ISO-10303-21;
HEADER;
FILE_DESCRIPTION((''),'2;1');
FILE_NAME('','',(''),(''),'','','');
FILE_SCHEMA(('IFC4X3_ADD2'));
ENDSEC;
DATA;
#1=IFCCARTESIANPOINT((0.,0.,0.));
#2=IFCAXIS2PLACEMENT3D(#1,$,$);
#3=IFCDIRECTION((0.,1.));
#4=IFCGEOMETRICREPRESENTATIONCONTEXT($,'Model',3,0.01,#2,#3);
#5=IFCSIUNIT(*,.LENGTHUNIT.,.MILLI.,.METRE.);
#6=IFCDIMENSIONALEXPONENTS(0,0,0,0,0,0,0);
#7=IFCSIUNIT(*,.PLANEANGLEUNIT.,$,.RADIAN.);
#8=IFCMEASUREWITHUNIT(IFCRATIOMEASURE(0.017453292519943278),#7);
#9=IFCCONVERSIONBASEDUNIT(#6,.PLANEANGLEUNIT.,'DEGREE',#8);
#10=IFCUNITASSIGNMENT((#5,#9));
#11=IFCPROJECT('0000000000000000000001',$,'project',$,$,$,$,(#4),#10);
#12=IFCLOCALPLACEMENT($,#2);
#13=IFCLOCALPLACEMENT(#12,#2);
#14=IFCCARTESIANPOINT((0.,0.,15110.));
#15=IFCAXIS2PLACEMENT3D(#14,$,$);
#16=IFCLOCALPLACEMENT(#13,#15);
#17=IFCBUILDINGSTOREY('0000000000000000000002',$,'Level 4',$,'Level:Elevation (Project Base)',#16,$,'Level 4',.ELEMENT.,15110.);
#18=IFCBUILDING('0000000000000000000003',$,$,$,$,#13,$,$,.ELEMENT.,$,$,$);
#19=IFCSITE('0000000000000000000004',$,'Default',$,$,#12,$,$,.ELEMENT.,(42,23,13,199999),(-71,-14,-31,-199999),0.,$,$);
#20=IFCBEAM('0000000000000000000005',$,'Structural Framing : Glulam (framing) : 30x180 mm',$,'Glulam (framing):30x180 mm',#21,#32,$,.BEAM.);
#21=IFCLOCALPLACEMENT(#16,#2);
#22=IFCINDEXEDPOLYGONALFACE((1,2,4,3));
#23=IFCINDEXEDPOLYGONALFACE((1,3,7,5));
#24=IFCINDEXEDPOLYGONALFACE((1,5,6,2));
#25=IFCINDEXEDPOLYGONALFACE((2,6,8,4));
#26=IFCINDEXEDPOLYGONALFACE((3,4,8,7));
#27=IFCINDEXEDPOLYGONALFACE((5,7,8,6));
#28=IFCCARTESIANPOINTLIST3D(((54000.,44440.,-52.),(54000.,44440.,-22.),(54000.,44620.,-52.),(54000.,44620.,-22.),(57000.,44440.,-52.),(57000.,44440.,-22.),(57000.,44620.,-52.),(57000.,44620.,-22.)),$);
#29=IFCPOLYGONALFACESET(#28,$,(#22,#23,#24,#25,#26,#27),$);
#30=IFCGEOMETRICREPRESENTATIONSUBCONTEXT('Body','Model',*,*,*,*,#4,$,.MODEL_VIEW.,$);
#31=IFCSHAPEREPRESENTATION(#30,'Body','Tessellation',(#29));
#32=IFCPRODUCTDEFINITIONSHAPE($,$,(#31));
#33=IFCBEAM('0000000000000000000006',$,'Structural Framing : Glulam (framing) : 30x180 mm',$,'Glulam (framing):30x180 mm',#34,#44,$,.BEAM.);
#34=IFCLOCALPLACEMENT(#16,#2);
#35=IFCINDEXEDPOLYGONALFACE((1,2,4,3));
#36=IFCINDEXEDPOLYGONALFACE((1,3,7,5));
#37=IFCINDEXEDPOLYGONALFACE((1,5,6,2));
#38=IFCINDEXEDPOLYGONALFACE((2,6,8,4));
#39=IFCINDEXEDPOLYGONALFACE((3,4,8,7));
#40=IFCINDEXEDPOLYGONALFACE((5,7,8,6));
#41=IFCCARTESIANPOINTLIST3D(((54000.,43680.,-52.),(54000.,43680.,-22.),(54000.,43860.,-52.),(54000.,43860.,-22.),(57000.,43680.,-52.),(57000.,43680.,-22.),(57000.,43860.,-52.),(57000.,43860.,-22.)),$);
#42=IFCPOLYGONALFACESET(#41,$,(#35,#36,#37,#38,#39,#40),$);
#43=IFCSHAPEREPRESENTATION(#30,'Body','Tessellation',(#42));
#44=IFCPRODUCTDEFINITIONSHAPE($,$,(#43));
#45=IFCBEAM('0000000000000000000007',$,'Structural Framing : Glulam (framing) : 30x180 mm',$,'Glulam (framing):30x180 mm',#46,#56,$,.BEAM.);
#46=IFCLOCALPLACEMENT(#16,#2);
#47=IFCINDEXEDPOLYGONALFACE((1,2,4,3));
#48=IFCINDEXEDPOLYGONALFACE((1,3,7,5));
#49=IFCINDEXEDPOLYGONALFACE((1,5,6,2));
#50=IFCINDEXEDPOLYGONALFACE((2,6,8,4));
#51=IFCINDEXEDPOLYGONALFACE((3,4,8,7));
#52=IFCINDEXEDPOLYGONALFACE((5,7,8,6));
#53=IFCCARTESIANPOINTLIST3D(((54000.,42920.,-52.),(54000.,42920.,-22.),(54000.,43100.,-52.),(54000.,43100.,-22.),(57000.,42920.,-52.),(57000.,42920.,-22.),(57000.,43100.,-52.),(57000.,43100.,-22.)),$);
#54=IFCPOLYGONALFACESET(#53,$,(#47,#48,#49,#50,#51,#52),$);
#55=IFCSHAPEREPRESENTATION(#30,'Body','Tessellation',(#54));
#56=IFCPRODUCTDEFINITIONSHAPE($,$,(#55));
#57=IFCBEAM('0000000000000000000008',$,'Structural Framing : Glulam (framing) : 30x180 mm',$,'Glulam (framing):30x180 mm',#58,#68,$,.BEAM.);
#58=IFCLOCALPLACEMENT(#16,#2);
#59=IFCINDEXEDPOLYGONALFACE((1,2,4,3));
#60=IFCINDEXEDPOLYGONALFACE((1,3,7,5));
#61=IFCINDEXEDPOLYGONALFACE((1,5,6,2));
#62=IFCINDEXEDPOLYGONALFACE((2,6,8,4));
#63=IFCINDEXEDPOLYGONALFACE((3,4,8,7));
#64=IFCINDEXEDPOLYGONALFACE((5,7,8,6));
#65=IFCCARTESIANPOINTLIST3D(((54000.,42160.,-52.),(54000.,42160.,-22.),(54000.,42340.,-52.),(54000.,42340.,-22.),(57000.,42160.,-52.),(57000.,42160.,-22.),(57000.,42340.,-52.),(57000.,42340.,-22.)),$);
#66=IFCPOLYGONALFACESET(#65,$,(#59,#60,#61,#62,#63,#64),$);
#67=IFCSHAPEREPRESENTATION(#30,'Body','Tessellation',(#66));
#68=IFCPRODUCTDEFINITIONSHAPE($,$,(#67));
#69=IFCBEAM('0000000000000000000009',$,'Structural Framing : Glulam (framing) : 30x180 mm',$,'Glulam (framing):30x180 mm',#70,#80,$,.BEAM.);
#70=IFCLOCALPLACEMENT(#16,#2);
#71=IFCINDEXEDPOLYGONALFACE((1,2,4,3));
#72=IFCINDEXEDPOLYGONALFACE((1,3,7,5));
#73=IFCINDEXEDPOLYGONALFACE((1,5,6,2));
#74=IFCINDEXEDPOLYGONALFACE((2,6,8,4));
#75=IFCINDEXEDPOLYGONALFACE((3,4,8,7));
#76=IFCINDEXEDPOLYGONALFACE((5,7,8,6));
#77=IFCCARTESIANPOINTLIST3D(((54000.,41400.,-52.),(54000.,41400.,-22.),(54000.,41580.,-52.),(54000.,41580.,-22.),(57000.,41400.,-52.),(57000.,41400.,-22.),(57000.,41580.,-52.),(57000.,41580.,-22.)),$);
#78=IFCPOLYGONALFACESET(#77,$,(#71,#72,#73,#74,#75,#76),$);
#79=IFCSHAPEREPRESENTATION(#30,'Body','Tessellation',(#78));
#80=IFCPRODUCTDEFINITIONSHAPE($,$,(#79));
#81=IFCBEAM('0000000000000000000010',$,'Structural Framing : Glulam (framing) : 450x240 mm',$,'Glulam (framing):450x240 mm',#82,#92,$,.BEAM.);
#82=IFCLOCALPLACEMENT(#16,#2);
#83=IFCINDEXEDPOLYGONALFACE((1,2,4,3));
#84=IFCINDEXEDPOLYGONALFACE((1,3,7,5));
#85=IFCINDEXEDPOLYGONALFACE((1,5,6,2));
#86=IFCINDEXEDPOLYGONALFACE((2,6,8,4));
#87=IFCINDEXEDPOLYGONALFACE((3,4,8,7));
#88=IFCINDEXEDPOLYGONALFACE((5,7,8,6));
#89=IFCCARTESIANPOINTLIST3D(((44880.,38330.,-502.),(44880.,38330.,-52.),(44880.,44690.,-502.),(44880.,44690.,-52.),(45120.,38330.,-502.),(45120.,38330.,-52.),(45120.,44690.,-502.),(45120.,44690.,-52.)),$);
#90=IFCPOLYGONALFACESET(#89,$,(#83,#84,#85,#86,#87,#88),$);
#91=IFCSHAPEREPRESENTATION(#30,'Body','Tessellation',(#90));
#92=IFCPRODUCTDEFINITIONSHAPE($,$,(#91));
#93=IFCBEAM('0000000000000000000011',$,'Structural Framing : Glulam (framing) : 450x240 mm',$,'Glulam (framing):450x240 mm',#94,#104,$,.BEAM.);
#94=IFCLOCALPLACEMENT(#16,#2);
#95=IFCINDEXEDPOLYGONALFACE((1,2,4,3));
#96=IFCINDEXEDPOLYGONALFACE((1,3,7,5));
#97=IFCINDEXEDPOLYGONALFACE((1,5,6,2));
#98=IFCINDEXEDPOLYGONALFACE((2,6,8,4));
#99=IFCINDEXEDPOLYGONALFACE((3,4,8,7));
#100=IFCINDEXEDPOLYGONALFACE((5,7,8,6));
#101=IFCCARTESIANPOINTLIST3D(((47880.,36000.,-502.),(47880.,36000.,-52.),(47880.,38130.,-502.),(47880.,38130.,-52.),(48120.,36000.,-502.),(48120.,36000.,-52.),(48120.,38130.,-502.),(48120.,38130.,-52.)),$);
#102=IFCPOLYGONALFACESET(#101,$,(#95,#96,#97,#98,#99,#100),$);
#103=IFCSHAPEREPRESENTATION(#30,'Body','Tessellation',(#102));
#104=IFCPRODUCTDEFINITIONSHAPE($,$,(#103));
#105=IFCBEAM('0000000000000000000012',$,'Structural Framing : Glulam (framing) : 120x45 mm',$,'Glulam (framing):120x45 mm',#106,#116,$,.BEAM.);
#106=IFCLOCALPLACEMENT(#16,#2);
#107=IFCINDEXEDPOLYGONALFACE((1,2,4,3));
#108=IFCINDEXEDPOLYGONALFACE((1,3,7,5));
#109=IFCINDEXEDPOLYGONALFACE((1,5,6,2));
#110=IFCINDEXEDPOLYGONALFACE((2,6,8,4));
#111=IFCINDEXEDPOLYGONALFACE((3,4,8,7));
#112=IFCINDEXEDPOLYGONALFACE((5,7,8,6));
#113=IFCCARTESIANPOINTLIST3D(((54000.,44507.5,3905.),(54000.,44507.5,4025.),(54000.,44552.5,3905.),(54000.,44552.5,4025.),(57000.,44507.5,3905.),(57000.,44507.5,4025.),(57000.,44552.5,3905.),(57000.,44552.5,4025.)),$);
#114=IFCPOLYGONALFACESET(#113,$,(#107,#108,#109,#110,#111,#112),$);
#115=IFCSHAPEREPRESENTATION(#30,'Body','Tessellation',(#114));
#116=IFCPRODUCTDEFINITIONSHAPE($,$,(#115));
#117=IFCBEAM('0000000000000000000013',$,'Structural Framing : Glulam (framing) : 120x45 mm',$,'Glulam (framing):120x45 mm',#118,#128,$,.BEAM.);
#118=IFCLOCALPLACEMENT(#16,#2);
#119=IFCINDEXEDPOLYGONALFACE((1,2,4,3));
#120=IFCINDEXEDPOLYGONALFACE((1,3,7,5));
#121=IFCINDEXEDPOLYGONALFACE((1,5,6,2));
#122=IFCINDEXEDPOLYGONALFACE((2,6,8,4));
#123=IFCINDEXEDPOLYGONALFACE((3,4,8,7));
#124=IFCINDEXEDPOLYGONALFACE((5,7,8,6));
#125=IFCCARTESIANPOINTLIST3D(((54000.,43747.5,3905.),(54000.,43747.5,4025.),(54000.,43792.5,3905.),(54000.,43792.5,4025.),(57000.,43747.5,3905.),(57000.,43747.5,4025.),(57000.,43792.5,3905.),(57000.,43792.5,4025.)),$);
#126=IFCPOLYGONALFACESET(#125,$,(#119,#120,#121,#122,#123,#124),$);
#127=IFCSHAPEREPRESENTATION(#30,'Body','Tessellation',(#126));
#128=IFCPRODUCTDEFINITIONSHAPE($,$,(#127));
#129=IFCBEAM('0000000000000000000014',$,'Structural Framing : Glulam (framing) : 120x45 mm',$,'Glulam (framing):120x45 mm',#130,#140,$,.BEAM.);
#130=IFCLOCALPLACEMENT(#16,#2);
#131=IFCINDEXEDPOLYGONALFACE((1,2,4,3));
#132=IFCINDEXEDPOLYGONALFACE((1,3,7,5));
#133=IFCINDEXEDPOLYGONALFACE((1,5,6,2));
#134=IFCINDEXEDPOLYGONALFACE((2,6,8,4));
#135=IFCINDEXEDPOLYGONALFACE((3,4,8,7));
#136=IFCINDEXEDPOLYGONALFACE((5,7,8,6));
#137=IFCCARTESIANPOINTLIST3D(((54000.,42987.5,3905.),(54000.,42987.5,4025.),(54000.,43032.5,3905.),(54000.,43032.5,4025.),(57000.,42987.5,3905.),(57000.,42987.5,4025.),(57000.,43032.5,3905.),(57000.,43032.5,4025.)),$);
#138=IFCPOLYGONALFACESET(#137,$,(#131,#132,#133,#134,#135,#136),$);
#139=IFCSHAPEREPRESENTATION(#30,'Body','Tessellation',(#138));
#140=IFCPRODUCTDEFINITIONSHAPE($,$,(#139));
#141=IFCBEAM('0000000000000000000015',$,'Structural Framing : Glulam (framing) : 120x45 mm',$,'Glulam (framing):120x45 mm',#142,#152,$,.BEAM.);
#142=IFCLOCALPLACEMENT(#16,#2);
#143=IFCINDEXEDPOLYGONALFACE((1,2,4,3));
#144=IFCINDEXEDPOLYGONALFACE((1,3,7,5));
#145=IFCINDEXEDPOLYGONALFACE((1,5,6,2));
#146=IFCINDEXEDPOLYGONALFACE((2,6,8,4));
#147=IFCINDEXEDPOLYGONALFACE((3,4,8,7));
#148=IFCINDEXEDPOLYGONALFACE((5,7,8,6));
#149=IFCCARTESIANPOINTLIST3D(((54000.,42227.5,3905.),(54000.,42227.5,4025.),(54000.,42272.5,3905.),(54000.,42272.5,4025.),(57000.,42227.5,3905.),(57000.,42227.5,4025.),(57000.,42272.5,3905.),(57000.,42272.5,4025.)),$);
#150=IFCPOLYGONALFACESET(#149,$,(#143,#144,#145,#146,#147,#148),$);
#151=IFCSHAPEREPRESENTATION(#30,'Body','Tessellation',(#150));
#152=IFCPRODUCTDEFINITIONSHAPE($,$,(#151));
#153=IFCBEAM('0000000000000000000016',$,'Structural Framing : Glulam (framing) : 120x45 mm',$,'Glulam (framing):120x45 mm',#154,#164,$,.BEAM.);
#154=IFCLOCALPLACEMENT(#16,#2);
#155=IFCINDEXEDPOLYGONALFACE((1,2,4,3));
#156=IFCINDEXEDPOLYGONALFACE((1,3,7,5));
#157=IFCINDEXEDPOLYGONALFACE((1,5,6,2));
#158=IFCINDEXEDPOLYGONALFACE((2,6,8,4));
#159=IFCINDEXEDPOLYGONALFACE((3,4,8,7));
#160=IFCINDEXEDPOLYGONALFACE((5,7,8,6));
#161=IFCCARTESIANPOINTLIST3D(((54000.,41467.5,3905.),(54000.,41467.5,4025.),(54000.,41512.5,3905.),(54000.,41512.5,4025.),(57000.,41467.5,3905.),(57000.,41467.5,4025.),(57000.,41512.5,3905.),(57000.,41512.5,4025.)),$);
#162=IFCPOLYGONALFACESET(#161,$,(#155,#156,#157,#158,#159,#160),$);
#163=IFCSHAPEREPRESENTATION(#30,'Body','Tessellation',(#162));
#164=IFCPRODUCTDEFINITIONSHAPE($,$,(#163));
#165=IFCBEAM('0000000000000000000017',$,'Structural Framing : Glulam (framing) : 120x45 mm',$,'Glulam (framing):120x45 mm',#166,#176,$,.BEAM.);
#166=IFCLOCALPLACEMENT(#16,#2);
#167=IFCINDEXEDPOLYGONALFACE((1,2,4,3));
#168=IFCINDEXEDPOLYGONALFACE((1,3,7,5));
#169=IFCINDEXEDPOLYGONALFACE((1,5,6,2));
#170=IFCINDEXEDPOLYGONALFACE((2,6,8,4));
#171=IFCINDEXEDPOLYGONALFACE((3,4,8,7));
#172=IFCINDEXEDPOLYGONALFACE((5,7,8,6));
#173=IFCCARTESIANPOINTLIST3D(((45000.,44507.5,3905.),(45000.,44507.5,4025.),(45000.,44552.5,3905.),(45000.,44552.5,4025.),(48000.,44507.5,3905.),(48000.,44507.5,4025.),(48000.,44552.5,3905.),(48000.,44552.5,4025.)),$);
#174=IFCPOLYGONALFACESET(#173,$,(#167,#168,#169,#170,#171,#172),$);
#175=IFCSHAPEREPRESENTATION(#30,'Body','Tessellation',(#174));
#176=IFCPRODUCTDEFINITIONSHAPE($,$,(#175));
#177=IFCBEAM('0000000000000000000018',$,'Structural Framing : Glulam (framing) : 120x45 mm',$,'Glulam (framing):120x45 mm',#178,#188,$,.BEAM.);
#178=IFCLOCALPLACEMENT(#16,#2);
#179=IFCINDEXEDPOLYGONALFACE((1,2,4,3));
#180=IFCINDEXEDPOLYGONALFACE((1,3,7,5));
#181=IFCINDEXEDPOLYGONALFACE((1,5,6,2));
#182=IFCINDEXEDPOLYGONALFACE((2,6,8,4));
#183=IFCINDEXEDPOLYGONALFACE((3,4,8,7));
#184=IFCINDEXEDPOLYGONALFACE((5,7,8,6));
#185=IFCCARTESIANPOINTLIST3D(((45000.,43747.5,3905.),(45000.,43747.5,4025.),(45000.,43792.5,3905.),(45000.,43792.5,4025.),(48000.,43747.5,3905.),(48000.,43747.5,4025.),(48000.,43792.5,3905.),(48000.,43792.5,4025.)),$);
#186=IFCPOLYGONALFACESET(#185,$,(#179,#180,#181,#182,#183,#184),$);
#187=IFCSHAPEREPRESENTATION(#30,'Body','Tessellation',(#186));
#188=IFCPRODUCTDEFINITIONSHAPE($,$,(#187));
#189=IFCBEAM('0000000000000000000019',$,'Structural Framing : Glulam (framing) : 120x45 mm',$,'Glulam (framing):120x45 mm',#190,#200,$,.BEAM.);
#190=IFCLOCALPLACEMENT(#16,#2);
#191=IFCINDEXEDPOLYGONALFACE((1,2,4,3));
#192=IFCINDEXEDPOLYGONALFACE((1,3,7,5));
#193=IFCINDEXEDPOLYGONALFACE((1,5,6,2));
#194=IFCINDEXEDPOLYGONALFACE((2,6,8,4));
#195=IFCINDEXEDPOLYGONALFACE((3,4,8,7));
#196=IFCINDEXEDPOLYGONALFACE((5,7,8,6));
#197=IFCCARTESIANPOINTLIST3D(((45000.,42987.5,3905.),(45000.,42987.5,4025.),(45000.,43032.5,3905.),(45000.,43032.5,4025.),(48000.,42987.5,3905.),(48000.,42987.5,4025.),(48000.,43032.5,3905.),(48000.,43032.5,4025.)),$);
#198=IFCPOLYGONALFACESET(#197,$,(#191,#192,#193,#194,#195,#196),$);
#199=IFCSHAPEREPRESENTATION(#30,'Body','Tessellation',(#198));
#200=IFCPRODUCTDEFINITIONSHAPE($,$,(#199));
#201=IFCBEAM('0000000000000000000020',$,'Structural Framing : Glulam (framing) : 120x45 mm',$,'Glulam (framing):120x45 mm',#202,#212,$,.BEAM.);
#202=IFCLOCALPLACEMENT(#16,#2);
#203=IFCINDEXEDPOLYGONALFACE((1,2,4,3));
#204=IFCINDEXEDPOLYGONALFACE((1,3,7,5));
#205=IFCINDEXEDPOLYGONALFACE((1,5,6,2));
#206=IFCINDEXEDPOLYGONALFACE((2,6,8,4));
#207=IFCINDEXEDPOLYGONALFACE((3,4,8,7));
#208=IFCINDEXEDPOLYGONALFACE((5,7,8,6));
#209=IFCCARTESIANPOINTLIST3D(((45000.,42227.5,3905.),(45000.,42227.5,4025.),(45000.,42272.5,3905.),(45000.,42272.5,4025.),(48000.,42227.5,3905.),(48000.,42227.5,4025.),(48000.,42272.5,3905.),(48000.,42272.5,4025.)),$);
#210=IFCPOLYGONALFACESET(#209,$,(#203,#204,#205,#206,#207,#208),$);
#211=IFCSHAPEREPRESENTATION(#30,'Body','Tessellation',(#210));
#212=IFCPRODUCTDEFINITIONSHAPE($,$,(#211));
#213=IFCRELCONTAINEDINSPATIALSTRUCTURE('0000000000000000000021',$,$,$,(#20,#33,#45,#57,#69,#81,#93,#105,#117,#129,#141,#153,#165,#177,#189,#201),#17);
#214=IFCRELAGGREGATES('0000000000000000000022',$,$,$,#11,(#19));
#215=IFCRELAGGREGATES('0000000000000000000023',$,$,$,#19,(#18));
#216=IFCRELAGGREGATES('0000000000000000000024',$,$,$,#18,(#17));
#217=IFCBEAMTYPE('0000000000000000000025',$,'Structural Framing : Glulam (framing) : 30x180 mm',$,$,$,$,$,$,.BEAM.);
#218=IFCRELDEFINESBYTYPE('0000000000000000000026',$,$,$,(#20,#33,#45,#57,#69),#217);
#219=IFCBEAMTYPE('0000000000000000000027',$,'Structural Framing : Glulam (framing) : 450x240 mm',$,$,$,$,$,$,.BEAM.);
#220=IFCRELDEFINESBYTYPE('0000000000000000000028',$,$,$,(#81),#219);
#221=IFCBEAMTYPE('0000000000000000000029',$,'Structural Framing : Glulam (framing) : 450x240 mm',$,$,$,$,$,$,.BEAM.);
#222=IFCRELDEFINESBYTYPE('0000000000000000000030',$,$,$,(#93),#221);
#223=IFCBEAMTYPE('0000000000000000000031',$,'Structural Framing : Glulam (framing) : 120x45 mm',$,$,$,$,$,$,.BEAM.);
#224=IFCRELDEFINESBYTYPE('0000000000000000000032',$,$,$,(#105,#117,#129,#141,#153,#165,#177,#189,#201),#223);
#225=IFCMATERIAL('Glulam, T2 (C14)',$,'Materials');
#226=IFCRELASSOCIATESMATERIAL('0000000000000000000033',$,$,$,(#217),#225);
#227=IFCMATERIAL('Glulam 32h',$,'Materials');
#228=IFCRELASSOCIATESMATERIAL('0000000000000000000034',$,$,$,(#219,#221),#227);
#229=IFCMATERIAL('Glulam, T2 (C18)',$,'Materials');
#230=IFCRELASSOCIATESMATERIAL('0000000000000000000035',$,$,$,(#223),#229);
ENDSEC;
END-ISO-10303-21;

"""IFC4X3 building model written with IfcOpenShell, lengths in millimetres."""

from ifc_helpers import new_model, entity, si_unit, converted_unit, direction, frame, origin, origin_2d_with_axis, place, context, subcontext, project, spatial, rectangle, extrude, source, transform, mapped, material, material_profile, profile_set, type_object, type_shapes, element, save


model = new_model("IFC4X3")

# Units and contexts
model_context = context("Model", 3, precision=0.01, world=origin(), true_north=direction((0.0, 1.0)))
body_context = subcontext(model_context, "Body", "Model", "MODEL_VIEW")
ifc_project = project(units=[si_unit("LENGTHUNIT", "METRE", prefix="MILLI"), converted_unit("PLANEANGLEUNIT", "DEGREE", entity("IfcRatioMeasure", 0.017453292519943278), si_unit("PLANEANGLEUNIT", "RADIAN"), dimensions=[0, 0, 0, 0, 0, 0, 0])], contexts=[model_context])

# Site, building, storey
site_placement = place(None, origin())
site = spatial("IfcSite", under=ifc_project, at=site_placement, Name="Default", CompositionType="ELEMENT", RefLatitude=(42, 23, 13, 199999), RefLongitude=(-71, -14, -31, -199999), RefElevation=0.0)
building_placement = place(site_placement, origin())
building = spatial("IfcBuilding", under=site, at=building_placement, CompositionType="ELEMENT")
storey_placement = place(building_placement, frame((0.0, 0.0, 15110.0)))
storey = spatial("IfcBuildingStorey", under=building, at=storey_placement, Name="Level 4", ObjectType="Level:Elevation (Project Base)", LongName="Level 4", CompositionType="ELEMENT", Elevation=15110.0)

# Beams
ifc_material_1 = material(Name="Glulam, T2 (C14)", Category="Materials")
ifc_material_profile_1 = material_profile(ifc_material_1, rectangle(XDim=30.0, YDim=180.0, at=origin_2d_with_axis()), Name="30x180 mm")
ifc_profile_set_1 = profile_set([ifc_material_profile_1], Name="30x180 mm")
beam_type_1 = type_object("IfcBeamType", Name="Structural Framing : Glulam (framing) : 30x180 mm", PredefinedType="BEAM", material=ifc_profile_set_1)
shared_shape_1 = source(origin(), body_context, "Body", "SweptSolid", [
    extrude(rectangle(XDim=30.0, YDim=180.0, at=origin_2d_with_axis()), frame((500.0, 0.0, 0.0), z_axis=(1.0, 0.0, 0.0), x_axis=(0.0, 0.0, -1.0)), (0.0, 0.0, 1.0), 3000.0),
])
type_shapes(beam_type_1, [shared_shape_1])
for number, where, name in (
    (1, (53500.0, 44530.0, -37.0), "Structural Framing : Glulam (framing) : 30x180 mm"),
    (2, (53500.0, 43770.0, -37.0), "Structural Framing : Glulam (framing) : 30x180 mm"),
    (3, (53500.0, 43010.0, -37.0), "Structural Framing : Glulam (framing) : 30x180 mm"),
    (4, (53500.0, 42250.0, -37.0), "Structural Framing : Glulam (framing) : 30x180 mm"),
    (5, (53500.0, 41490.0, -37.0), "Structural Framing : Glulam (framing) : 30x180 mm"),
):
    element("IfcBeam", number, at=place(storey_placement, frame(where)), inside=storey, type_object=beam_type_1, Name=name, ObjectType="Glulam (framing):30x180 mm", PredefinedType="BEAM", context=body_context, shape_type="MappedRepresentation", body=[
        mapped(shared_shape_1, transform((0.0, 0.0, 0.0), scale=1.0)),
    ])
ifc_material_2 = material(Name="Glulam 32h", Category="Materials")
ifc_material_profile_2 = material_profile(ifc_material_2, rectangle(XDim=450.0, YDim=240.0, at=origin_2d_with_axis()), Name="450x240 mm")
ifc_profile_set_2 = profile_set([ifc_material_profile_2], Name="450x240 mm")
beam_type_2 = type_object("IfcBeamType", Name="Structural Framing : Glulam (framing) : 450x240 mm", PredefinedType="BEAM", material=ifc_profile_set_2)
shared_shape_2 = source(origin(), body_context, "Body", "SweptSolid", [
    extrude(rectangle(XDim=450.0, YDim=240.0, at=origin_2d_with_axis()), frame((-3206.2, 0.0, 0.0), z_axis=(1.0, 0.0, 0.0), x_axis=(0.0, 0.0, -1.0)), (0.0, 0.0, 1.0), 6360.0),
])
type_shapes(beam_type_2, [shared_shape_2])
beam_1_placement = place(storey_placement, frame((45000.0, 41483.7, -277.0), z_axis=(0.0, 0.0, 1.0), x_axis=(0.0, -1.0, 0.0)))
element("IfcBeam", 6, at=beam_1_placement, inside=storey, type_object=beam_type_2, Name="Structural Framing : Glulam (framing) : 450x240 mm", ObjectType="Glulam (framing):450x240 mm", PredefinedType="BEAM", context=body_context, shape_type="MappedRepresentation", body=[
    mapped(shared_shape_2, transform((0.0, 0.0, 0.0), scale=1.0)),
])
beam_type_3 = type_object("IfcBeamType", Name="Structural Framing : Glulam (framing) : 450x240 mm", PredefinedType="BEAM", material=ifc_profile_set_2)
shared_shape_3 = source(origin(), body_context, "Body", "SweptSolid", [
    extrude(rectangle(XDim=450.0, YDim=240.0, at=origin_2d_with_axis()), frame((2853.7, 0.0, 0.0), z_axis=(1.0, 0.0, 0.0), x_axis=(0.0, 0.0, -1.0)), (0.0, 0.0, 1.0), 2130.0),
])
type_shapes(beam_type_3, [shared_shape_3])
beam_2_placement = place(storey_placement, frame((48000.0, 40983.7, -277.0), z_axis=(0.0, 0.0, 1.0), x_axis=(0.0, -1.0, 0.0)))
element("IfcBeam", 7, at=beam_2_placement, inside=storey, type_object=beam_type_3, Name="Structural Framing : Glulam (framing) : 450x240 mm", ObjectType="Glulam (framing):450x240 mm", PredefinedType="BEAM", context=body_context, shape_type="MappedRepresentation", body=[
    mapped(shared_shape_3, transform((0.0, 0.0, 0.0), scale=1.0)),
])
ifc_material_3 = material(Name="Glulam, T2 (C18)", Category="Materials")
ifc_material_profile_3 = material_profile(ifc_material_3, rectangle(XDim=120.0, YDim=45.0, at=origin_2d_with_axis()), Name="120x45 mm")
ifc_profile_set_3 = profile_set([ifc_material_profile_3], Name="120x45 mm")
beam_type_4 = type_object("IfcBeamType", Name="Structural Framing : Glulam (framing) : 120x45 mm", PredefinedType="BEAM", material=ifc_profile_set_3)
shared_shape_4 = source(origin(), body_context, "Body", "SweptSolid", [
    extrude(rectangle(XDim=120.0, YDim=45.0, at=origin_2d_with_axis()), frame((500.0, 0.0, 0.0), z_axis=(1.0, 0.0, 0.0), x_axis=(0.0, 0.0, -1.0)), (0.0, 0.0, 1.0), 3000.0),
])
type_shapes(beam_type_4, [shared_shape_4])
for number, where, name in (
    (8, (53500.0, 44530.0, 3965.0), "Structural Framing : Glulam (framing) : 120x45 mm"),
    (9, (53500.0, 43770.0, 3965.0), "Structural Framing : Glulam (framing) : 120x45 mm"),
    (10, (53500.0, 43010.0, 3965.0), "Structural Framing : Glulam (framing) : 120x45 mm"),
    (11, (53500.0, 42250.0, 3965.0), "Structural Framing : Glulam (framing) : 120x45 mm"),
    (12, (53500.0, 41490.0, 3965.0), "Structural Framing : Glulam (framing) : 120x45 mm"),
    (13, (44500.0, 44530.0, 3965.0), "Structural Framing : Glulam (framing) : 120x45 mm"),
    (14, (44500.0, 43770.0, 3965.0), "Structural Framing : Glulam (framing) : 120x45 mm"),
    (15, (44500.0, 43010.0, 3965.0), "Structural Framing : Glulam (framing) : 120x45 mm"),
    (16, (44500.0, 42250.0, 3965.0), "Structural Framing : Glulam (framing) : 120x45 mm"),
):
    element("IfcBeam", number, at=place(storey_placement, frame(where)), inside=storey, type_object=beam_type_4, Name=name, ObjectType="Glulam (framing):120x45 mm", PredefinedType="BEAM", context=body_context, shape_type="MappedRepresentation", body=[
        mapped(shared_shape_4, transform((0.0, 0.0, 0.0), scale=1.0)),
    ])

save(model, "model.ifc")
